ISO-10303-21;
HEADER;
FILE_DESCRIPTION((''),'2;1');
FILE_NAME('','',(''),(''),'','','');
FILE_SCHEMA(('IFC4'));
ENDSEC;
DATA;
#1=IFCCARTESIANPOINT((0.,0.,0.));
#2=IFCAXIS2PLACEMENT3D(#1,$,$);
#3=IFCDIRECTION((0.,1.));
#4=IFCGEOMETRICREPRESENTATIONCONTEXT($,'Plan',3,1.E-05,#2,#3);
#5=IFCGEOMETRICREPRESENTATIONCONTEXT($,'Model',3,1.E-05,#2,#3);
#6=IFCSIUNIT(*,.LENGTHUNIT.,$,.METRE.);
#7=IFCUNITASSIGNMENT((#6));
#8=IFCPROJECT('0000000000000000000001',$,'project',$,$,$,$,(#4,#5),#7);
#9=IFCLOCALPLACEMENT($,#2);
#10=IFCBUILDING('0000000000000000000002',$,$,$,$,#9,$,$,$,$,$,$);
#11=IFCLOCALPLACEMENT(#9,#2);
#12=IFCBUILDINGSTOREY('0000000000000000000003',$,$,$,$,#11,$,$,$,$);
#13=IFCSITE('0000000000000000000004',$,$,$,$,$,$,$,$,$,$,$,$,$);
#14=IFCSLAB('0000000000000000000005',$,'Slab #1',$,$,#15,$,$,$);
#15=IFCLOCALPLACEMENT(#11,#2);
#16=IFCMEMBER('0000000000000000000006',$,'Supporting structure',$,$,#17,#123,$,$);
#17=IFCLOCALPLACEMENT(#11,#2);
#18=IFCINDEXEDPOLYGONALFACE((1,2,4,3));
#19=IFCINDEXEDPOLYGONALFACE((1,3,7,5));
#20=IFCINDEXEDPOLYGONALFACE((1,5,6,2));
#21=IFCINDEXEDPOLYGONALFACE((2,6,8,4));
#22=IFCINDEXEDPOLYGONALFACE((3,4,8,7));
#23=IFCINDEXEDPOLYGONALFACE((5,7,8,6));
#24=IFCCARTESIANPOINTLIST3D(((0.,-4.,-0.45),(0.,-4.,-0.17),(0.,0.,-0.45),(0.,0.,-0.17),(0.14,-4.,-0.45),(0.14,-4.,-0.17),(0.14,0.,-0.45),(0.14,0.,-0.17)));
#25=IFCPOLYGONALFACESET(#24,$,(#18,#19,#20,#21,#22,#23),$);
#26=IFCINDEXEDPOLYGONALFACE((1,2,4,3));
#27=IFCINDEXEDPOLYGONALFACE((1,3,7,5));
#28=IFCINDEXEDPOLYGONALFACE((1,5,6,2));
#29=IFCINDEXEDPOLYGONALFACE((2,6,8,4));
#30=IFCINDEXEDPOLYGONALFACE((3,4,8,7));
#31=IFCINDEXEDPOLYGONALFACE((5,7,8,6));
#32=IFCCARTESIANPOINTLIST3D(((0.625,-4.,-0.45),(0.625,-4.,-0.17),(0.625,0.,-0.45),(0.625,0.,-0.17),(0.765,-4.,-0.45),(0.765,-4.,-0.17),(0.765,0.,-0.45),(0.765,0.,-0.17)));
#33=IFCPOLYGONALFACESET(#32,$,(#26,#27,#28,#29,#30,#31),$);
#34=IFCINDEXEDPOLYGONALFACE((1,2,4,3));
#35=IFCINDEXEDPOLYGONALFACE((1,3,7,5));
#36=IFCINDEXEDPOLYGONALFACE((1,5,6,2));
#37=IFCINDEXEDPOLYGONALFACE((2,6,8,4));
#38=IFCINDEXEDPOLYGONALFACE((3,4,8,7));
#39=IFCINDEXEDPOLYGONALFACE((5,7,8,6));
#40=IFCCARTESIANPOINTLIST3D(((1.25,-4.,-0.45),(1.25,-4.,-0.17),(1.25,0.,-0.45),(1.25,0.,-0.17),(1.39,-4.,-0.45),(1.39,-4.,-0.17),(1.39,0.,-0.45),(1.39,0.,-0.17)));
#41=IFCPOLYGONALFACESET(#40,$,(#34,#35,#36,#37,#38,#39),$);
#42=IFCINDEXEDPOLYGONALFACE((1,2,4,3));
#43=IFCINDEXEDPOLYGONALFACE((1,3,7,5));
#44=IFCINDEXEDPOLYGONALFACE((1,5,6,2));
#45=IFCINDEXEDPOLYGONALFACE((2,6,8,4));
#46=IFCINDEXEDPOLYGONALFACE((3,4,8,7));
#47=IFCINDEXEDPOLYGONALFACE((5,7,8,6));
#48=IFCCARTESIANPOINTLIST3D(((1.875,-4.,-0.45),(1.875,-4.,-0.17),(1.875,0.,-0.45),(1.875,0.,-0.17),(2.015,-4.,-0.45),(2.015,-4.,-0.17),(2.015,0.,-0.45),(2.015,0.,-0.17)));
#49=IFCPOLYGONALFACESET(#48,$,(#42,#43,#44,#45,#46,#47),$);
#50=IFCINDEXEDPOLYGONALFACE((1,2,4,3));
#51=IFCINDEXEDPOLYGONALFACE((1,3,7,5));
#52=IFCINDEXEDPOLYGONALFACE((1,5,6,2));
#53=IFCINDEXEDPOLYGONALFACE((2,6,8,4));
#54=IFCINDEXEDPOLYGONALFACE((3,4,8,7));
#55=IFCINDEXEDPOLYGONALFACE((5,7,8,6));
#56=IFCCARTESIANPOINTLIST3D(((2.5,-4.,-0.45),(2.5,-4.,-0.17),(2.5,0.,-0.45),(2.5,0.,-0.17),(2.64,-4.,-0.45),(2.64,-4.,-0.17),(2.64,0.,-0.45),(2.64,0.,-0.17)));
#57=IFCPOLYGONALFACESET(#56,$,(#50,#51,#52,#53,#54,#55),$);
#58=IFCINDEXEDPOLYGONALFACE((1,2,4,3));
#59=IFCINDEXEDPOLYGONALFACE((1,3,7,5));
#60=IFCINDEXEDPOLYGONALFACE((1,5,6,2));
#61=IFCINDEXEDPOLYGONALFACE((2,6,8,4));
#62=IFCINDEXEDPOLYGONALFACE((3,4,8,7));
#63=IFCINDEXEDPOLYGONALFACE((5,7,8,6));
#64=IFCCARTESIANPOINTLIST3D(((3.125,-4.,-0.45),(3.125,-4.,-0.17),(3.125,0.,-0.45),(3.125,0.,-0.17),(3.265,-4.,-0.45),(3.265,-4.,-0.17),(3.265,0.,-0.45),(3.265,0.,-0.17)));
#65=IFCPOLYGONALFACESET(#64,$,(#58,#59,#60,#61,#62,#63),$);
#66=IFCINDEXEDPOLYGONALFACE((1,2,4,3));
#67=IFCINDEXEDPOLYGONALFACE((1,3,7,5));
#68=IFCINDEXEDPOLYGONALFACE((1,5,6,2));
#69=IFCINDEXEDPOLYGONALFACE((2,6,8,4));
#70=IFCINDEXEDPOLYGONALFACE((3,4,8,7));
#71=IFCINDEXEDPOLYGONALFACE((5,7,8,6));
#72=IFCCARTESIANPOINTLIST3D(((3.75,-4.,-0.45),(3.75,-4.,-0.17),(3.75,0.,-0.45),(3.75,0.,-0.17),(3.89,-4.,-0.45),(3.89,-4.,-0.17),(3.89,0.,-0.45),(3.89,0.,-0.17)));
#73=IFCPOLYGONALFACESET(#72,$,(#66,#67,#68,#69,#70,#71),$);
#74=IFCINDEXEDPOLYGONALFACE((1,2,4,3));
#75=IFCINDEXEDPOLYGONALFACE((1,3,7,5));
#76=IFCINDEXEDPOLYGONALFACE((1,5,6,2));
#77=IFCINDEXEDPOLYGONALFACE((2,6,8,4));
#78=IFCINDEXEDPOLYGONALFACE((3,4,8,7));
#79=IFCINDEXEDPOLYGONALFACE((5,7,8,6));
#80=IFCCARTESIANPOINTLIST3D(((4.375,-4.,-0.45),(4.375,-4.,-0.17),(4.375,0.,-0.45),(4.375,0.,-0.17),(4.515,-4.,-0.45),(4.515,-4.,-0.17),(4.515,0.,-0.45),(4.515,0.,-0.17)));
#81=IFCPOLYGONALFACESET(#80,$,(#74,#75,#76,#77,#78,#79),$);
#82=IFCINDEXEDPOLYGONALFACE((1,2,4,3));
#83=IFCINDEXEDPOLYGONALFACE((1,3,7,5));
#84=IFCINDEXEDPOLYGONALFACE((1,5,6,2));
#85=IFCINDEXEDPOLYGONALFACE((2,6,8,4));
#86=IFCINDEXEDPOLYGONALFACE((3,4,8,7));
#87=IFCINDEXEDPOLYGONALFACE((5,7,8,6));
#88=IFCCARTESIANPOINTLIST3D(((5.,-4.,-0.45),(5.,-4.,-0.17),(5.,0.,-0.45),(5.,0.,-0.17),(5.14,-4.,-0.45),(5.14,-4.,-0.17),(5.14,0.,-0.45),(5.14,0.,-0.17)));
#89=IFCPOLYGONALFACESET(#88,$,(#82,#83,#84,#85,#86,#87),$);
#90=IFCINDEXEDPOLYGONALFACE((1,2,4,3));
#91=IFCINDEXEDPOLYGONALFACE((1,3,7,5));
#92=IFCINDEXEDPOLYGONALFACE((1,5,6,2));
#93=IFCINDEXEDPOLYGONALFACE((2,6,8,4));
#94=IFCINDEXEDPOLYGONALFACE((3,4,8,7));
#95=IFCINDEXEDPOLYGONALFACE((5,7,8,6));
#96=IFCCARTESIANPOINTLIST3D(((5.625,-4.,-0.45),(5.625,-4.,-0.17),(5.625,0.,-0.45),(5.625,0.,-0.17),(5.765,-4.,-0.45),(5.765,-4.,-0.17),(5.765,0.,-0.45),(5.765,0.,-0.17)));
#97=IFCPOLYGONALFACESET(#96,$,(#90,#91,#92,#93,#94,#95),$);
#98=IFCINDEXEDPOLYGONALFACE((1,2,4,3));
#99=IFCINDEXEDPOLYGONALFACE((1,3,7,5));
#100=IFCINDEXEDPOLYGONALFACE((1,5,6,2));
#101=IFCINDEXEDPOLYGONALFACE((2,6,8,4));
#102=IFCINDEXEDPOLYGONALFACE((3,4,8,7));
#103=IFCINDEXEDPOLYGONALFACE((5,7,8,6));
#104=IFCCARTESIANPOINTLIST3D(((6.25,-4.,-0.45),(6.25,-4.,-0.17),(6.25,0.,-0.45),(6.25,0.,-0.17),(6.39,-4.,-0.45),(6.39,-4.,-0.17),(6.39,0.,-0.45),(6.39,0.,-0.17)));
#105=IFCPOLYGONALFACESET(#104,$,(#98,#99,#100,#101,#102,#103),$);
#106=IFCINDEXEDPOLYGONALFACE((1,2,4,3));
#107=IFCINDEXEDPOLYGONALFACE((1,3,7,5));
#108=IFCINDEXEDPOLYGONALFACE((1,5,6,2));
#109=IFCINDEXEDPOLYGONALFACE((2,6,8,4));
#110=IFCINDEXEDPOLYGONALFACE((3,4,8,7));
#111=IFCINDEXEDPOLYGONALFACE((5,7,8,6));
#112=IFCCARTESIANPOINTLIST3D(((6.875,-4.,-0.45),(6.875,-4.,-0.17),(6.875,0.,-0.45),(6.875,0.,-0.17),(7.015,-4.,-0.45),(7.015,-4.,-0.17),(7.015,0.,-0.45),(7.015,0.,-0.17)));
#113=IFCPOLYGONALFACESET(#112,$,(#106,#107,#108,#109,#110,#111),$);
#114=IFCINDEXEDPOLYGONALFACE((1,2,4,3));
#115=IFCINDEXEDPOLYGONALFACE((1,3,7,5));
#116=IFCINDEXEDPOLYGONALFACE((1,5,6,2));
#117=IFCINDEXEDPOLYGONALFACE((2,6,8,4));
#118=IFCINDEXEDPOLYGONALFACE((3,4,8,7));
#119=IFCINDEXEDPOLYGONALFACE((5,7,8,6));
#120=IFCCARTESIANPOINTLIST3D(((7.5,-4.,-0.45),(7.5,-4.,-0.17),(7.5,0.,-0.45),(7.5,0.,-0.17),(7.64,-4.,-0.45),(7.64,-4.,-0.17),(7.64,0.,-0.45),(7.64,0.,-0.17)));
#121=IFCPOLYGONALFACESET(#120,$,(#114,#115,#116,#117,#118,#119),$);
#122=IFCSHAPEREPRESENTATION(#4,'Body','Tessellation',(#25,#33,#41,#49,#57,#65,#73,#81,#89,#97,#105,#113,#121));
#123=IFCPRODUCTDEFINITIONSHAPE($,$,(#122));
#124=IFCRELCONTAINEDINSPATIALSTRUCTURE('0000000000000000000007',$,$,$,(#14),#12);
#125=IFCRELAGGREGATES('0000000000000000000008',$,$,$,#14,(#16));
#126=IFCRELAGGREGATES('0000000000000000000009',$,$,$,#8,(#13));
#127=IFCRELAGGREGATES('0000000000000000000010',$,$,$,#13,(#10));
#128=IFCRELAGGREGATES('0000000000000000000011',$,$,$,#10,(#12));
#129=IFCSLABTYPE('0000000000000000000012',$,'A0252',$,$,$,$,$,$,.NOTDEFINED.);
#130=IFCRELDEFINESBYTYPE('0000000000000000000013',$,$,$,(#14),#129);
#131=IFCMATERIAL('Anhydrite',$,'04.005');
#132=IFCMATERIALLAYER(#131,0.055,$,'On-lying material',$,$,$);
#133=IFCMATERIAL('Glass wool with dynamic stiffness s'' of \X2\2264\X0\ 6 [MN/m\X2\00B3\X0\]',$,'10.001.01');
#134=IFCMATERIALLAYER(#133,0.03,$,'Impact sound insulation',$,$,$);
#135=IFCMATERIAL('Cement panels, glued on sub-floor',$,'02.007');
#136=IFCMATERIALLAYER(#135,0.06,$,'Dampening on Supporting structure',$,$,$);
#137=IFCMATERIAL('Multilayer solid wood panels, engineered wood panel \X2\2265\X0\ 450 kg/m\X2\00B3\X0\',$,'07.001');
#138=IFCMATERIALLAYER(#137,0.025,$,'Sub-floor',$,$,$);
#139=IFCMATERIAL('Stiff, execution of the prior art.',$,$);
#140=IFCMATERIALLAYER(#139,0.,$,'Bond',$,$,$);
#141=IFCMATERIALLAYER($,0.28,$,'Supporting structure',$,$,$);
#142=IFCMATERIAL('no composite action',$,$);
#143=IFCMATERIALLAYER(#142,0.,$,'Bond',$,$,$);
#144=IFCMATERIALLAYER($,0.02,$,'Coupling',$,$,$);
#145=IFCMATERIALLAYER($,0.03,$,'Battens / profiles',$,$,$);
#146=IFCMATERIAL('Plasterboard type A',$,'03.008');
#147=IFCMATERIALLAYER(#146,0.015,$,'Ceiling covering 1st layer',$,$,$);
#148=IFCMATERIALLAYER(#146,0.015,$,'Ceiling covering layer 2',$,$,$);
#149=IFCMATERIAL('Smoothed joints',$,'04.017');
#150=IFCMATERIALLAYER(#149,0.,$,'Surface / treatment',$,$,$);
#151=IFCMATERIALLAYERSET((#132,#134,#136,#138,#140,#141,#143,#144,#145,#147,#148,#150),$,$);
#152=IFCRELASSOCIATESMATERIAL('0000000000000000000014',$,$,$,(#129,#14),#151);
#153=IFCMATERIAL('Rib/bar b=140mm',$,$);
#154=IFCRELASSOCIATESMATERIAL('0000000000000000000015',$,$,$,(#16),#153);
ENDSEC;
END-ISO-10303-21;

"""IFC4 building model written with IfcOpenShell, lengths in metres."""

from ifc_helpers import new_model, si_unit, direction, frame, frame_2d, origin, place, context, project, spatial, rectangle, extrude, material, layer, layer_set, type_object, element, aggregate, save


model = new_model("IFC4")

# Units and contexts
plan_context = context("Plan", 3, precision=1e-05, world=origin(), true_north=direction((0.0, 1.0)))
model_context = context("Model", 3, precision=1e-05, world=origin(), true_north=direction((0.0, 1.0)))
ifc_project = project(units=[si_unit("LENGTHUNIT", "METRE")], contexts=[plan_context, model_context])

# Site, building, storey
site = spatial("IfcSite", under=ifc_project)
building_placement = place(None, origin())
building = spatial("IfcBuilding", under=site, at=building_placement)
storey_placement = place(building_placement, origin())
storey = spatial("IfcBuildingStorey", under=building, at=storey_placement)

# Slab, member
ifc_material_1 = material(Name="Anhydrite", Category="04.005")
ifc_layer_1 = layer(ifc_material_1, 0.055, Name="On-lying material")
ifc_material_2 = material(Name="Glass wool with dynamic stiffness s' of ≤ 6 [MN/m³]", Category="10.001.01")
ifc_layer_2 = layer(ifc_material_2, 0.03, Name="Impact sound insulation")
ifc_material_3 = material(Name="Cement panels, glued on sub-floor", Category="02.007")
ifc_layer_3 = layer(ifc_material_3, 0.06, Name="Dampening on Supporting structure")
ifc_material_4 = material(Name="Multilayer solid wood panels, engineered wood panel ≥ 450 kg/m³", Category="07.001")
ifc_layer_4 = layer(ifc_material_4, 0.025, Name="Sub-floor")
ifc_material_5 = material(Name="Stiff, execution of the prior art.")
ifc_layer_5 = layer(ifc_material_5, 0.0, Name="Bond")
ifc_layer_6 = layer(None, 0.28, Name="Supporting structure")
ifc_material_6 = material(Name="no composite action")
ifc_layer_7 = layer(ifc_material_6, 0.0, Name="Bond")
ifc_layer_8 = layer(None, 0.02, Name="Coupling")
ifc_layer_9 = layer(None, 0.03, Name="Battens / profiles")
ifc_material_7 = material(Name="Plasterboard type A", Category="03.008")
ifc_layer_10 = layer(ifc_material_7, 0.015, Name="Ceiling covering 1st layer")
ifc_layer_11 = layer(ifc_material_7, 0.015, Name="Ceiling covering layer 2")
ifc_material_8 = material(Name="Smoothed joints", Category="04.017")
ifc_layer_12 = layer(ifc_material_8, 0.0, Name="Surface / treatment")
ifc_layer_set = layer_set([ifc_layer_1, ifc_layer_2, ifc_layer_3, ifc_layer_4, ifc_layer_5, ifc_layer_6, ifc_layer_7, ifc_layer_8, ifc_layer_9, ifc_layer_10, ifc_layer_11, ifc_layer_12])
slab_type = type_object("IfcSlabType", Name="A0252", PredefinedType="NOTDEFINED", material=ifc_layer_set)
slab_placement = place(None, frame((0.0, 0.0, 0.0), z_axis=(0.0, 0.0, -1.0), x_axis=(1.0, 0.0, 0.0)))
slab = element("IfcSlab", 1, at=slab_placement, inside=storey, type_object=slab_type, material=ifc_layer_set, Name="Slab #1")
ifc_material_9 = material(Name="Rib/bar b=140mm")
member_1_placement = place(slab_placement, origin())
member_1 = element("IfcMember", 2, at=member_1_placement, material=ifc_material_9, Name="Supporting structure", context=plan_context, shape_type="SweptSolid", body=[
    extrude(rectangle(XDim=0.14, YDim=0.28, at=frame_2d((0.07, 0.14), x_axis=(1.0, 0.0))), frame((0.0, 4.0, 0.17), z_axis=(0.0, -1.0, 0.0), x_axis=(1.0, 0.0, 0.0)), (0.0, 0.0, 1.0), 4.0),
    extrude(rectangle(XDim=0.14, YDim=0.28, at=frame_2d((0.07, 0.14), x_axis=(1.0, 0.0))), frame((0.625, 4.0, 0.17), z_axis=(0.0, -1.0, 0.0), x_axis=(1.0, 0.0, 0.0)), (0.0, 0.0, 1.0), 4.0),
    extrude(rectangle(XDim=0.14, YDim=0.28, at=frame_2d((0.07, 0.14), x_axis=(1.0, 0.0))), frame((1.25, 4.0, 0.17), z_axis=(0.0, -1.0, 0.0), x_axis=(1.0, 0.0, 0.0)), (0.0, 0.0, 1.0), 4.0),
    extrude(rectangle(XDim=0.14, YDim=0.28, at=frame_2d((0.07, 0.14), x_axis=(1.0, 0.0))), frame((1.875, 4.0, 0.17), z_axis=(0.0, -1.0, 0.0), x_axis=(1.0, 0.0, 0.0)), (0.0, 0.0, 1.0), 4.0),
    extrude(rectangle(XDim=0.14, YDim=0.28, at=frame_2d((0.07, 0.14), x_axis=(1.0, 0.0))), frame((2.5, 4.0, 0.17), z_axis=(0.0, -1.0, 0.0), x_axis=(1.0, 0.0, 0.0)), (0.0, 0.0, 1.0), 4.0),
    extrude(rectangle(XDim=0.14, YDim=0.28, at=frame_2d((0.07, 0.14), x_axis=(1.0, 0.0))), frame((3.125, 4.0, 0.17), z_axis=(0.0, -1.0, 0.0), x_axis=(1.0, 0.0, 0.0)), (0.0, 0.0, 1.0), 4.0),
    extrude(rectangle(XDim=0.14, YDim=0.28, at=frame_2d((0.07, 0.14), x_axis=(1.0, 0.0))), frame((3.75, 4.0, 0.17), z_axis=(0.0, -1.0, 0.0), x_axis=(1.0, 0.0, 0.0)), (0.0, 0.0, 1.0), 4.0),
    extrude(rectangle(XDim=0.14, YDim=0.28, at=frame_2d((0.07, 0.14), x_axis=(1.0, 0.0))), frame((4.375, 4.0, 0.17), z_axis=(0.0, -1.0, 0.0), x_axis=(1.0, 0.0, 0.0)), (0.0, 0.0, 1.0), 4.0),
    extrude(rectangle(XDim=0.14, YDim=0.28, at=frame_2d((0.07, 0.14), x_axis=(1.0, 0.0))), frame((5.0, 4.0, 0.17), z_axis=(0.0, -1.0, 0.0), x_axis=(1.0, 0.0, 0.0)), (0.0, 0.0, 1.0), 4.0),
    extrude(rectangle(XDim=0.14, YDim=0.28, at=frame_2d((0.07, 0.14), x_axis=(1.0, 0.0))), frame((5.625, 4.0, 0.17), z_axis=(0.0, -1.0, 0.0), x_axis=(1.0, 0.0, 0.0)), (0.0, 0.0, 1.0), 4.0),
    extrude(rectangle(XDim=0.14, YDim=0.28, at=frame_2d((0.07, 0.14), x_axis=(1.0, 0.0))), frame((6.25, 4.0, 0.17), z_axis=(0.0, -1.0, 0.0), x_axis=(1.0, 0.0, 0.0)), (0.0, 0.0, 1.0), 4.0),
    extrude(rectangle(XDim=0.14, YDim=0.28, at=frame_2d((0.07, 0.14), x_axis=(1.0, 0.0))), frame((6.875, 4.0, 0.17), z_axis=(0.0, -1.0, 0.0), x_axis=(1.0, 0.0, 0.0)), (0.0, 0.0, 1.0), 4.0),
    extrude(rectangle(XDim=0.14, YDim=0.28, at=frame_2d((0.07, 0.14), x_axis=(1.0, 0.0))), frame((7.5, 4.0, 0.17), z_axis=(0.0, -1.0, 0.0), x_axis=(1.0, 0.0, 0.0)), (0.0, 0.0, 1.0), 4.0),
])
aggregate(slab, [member_1])

save(model, "model.ifc")
